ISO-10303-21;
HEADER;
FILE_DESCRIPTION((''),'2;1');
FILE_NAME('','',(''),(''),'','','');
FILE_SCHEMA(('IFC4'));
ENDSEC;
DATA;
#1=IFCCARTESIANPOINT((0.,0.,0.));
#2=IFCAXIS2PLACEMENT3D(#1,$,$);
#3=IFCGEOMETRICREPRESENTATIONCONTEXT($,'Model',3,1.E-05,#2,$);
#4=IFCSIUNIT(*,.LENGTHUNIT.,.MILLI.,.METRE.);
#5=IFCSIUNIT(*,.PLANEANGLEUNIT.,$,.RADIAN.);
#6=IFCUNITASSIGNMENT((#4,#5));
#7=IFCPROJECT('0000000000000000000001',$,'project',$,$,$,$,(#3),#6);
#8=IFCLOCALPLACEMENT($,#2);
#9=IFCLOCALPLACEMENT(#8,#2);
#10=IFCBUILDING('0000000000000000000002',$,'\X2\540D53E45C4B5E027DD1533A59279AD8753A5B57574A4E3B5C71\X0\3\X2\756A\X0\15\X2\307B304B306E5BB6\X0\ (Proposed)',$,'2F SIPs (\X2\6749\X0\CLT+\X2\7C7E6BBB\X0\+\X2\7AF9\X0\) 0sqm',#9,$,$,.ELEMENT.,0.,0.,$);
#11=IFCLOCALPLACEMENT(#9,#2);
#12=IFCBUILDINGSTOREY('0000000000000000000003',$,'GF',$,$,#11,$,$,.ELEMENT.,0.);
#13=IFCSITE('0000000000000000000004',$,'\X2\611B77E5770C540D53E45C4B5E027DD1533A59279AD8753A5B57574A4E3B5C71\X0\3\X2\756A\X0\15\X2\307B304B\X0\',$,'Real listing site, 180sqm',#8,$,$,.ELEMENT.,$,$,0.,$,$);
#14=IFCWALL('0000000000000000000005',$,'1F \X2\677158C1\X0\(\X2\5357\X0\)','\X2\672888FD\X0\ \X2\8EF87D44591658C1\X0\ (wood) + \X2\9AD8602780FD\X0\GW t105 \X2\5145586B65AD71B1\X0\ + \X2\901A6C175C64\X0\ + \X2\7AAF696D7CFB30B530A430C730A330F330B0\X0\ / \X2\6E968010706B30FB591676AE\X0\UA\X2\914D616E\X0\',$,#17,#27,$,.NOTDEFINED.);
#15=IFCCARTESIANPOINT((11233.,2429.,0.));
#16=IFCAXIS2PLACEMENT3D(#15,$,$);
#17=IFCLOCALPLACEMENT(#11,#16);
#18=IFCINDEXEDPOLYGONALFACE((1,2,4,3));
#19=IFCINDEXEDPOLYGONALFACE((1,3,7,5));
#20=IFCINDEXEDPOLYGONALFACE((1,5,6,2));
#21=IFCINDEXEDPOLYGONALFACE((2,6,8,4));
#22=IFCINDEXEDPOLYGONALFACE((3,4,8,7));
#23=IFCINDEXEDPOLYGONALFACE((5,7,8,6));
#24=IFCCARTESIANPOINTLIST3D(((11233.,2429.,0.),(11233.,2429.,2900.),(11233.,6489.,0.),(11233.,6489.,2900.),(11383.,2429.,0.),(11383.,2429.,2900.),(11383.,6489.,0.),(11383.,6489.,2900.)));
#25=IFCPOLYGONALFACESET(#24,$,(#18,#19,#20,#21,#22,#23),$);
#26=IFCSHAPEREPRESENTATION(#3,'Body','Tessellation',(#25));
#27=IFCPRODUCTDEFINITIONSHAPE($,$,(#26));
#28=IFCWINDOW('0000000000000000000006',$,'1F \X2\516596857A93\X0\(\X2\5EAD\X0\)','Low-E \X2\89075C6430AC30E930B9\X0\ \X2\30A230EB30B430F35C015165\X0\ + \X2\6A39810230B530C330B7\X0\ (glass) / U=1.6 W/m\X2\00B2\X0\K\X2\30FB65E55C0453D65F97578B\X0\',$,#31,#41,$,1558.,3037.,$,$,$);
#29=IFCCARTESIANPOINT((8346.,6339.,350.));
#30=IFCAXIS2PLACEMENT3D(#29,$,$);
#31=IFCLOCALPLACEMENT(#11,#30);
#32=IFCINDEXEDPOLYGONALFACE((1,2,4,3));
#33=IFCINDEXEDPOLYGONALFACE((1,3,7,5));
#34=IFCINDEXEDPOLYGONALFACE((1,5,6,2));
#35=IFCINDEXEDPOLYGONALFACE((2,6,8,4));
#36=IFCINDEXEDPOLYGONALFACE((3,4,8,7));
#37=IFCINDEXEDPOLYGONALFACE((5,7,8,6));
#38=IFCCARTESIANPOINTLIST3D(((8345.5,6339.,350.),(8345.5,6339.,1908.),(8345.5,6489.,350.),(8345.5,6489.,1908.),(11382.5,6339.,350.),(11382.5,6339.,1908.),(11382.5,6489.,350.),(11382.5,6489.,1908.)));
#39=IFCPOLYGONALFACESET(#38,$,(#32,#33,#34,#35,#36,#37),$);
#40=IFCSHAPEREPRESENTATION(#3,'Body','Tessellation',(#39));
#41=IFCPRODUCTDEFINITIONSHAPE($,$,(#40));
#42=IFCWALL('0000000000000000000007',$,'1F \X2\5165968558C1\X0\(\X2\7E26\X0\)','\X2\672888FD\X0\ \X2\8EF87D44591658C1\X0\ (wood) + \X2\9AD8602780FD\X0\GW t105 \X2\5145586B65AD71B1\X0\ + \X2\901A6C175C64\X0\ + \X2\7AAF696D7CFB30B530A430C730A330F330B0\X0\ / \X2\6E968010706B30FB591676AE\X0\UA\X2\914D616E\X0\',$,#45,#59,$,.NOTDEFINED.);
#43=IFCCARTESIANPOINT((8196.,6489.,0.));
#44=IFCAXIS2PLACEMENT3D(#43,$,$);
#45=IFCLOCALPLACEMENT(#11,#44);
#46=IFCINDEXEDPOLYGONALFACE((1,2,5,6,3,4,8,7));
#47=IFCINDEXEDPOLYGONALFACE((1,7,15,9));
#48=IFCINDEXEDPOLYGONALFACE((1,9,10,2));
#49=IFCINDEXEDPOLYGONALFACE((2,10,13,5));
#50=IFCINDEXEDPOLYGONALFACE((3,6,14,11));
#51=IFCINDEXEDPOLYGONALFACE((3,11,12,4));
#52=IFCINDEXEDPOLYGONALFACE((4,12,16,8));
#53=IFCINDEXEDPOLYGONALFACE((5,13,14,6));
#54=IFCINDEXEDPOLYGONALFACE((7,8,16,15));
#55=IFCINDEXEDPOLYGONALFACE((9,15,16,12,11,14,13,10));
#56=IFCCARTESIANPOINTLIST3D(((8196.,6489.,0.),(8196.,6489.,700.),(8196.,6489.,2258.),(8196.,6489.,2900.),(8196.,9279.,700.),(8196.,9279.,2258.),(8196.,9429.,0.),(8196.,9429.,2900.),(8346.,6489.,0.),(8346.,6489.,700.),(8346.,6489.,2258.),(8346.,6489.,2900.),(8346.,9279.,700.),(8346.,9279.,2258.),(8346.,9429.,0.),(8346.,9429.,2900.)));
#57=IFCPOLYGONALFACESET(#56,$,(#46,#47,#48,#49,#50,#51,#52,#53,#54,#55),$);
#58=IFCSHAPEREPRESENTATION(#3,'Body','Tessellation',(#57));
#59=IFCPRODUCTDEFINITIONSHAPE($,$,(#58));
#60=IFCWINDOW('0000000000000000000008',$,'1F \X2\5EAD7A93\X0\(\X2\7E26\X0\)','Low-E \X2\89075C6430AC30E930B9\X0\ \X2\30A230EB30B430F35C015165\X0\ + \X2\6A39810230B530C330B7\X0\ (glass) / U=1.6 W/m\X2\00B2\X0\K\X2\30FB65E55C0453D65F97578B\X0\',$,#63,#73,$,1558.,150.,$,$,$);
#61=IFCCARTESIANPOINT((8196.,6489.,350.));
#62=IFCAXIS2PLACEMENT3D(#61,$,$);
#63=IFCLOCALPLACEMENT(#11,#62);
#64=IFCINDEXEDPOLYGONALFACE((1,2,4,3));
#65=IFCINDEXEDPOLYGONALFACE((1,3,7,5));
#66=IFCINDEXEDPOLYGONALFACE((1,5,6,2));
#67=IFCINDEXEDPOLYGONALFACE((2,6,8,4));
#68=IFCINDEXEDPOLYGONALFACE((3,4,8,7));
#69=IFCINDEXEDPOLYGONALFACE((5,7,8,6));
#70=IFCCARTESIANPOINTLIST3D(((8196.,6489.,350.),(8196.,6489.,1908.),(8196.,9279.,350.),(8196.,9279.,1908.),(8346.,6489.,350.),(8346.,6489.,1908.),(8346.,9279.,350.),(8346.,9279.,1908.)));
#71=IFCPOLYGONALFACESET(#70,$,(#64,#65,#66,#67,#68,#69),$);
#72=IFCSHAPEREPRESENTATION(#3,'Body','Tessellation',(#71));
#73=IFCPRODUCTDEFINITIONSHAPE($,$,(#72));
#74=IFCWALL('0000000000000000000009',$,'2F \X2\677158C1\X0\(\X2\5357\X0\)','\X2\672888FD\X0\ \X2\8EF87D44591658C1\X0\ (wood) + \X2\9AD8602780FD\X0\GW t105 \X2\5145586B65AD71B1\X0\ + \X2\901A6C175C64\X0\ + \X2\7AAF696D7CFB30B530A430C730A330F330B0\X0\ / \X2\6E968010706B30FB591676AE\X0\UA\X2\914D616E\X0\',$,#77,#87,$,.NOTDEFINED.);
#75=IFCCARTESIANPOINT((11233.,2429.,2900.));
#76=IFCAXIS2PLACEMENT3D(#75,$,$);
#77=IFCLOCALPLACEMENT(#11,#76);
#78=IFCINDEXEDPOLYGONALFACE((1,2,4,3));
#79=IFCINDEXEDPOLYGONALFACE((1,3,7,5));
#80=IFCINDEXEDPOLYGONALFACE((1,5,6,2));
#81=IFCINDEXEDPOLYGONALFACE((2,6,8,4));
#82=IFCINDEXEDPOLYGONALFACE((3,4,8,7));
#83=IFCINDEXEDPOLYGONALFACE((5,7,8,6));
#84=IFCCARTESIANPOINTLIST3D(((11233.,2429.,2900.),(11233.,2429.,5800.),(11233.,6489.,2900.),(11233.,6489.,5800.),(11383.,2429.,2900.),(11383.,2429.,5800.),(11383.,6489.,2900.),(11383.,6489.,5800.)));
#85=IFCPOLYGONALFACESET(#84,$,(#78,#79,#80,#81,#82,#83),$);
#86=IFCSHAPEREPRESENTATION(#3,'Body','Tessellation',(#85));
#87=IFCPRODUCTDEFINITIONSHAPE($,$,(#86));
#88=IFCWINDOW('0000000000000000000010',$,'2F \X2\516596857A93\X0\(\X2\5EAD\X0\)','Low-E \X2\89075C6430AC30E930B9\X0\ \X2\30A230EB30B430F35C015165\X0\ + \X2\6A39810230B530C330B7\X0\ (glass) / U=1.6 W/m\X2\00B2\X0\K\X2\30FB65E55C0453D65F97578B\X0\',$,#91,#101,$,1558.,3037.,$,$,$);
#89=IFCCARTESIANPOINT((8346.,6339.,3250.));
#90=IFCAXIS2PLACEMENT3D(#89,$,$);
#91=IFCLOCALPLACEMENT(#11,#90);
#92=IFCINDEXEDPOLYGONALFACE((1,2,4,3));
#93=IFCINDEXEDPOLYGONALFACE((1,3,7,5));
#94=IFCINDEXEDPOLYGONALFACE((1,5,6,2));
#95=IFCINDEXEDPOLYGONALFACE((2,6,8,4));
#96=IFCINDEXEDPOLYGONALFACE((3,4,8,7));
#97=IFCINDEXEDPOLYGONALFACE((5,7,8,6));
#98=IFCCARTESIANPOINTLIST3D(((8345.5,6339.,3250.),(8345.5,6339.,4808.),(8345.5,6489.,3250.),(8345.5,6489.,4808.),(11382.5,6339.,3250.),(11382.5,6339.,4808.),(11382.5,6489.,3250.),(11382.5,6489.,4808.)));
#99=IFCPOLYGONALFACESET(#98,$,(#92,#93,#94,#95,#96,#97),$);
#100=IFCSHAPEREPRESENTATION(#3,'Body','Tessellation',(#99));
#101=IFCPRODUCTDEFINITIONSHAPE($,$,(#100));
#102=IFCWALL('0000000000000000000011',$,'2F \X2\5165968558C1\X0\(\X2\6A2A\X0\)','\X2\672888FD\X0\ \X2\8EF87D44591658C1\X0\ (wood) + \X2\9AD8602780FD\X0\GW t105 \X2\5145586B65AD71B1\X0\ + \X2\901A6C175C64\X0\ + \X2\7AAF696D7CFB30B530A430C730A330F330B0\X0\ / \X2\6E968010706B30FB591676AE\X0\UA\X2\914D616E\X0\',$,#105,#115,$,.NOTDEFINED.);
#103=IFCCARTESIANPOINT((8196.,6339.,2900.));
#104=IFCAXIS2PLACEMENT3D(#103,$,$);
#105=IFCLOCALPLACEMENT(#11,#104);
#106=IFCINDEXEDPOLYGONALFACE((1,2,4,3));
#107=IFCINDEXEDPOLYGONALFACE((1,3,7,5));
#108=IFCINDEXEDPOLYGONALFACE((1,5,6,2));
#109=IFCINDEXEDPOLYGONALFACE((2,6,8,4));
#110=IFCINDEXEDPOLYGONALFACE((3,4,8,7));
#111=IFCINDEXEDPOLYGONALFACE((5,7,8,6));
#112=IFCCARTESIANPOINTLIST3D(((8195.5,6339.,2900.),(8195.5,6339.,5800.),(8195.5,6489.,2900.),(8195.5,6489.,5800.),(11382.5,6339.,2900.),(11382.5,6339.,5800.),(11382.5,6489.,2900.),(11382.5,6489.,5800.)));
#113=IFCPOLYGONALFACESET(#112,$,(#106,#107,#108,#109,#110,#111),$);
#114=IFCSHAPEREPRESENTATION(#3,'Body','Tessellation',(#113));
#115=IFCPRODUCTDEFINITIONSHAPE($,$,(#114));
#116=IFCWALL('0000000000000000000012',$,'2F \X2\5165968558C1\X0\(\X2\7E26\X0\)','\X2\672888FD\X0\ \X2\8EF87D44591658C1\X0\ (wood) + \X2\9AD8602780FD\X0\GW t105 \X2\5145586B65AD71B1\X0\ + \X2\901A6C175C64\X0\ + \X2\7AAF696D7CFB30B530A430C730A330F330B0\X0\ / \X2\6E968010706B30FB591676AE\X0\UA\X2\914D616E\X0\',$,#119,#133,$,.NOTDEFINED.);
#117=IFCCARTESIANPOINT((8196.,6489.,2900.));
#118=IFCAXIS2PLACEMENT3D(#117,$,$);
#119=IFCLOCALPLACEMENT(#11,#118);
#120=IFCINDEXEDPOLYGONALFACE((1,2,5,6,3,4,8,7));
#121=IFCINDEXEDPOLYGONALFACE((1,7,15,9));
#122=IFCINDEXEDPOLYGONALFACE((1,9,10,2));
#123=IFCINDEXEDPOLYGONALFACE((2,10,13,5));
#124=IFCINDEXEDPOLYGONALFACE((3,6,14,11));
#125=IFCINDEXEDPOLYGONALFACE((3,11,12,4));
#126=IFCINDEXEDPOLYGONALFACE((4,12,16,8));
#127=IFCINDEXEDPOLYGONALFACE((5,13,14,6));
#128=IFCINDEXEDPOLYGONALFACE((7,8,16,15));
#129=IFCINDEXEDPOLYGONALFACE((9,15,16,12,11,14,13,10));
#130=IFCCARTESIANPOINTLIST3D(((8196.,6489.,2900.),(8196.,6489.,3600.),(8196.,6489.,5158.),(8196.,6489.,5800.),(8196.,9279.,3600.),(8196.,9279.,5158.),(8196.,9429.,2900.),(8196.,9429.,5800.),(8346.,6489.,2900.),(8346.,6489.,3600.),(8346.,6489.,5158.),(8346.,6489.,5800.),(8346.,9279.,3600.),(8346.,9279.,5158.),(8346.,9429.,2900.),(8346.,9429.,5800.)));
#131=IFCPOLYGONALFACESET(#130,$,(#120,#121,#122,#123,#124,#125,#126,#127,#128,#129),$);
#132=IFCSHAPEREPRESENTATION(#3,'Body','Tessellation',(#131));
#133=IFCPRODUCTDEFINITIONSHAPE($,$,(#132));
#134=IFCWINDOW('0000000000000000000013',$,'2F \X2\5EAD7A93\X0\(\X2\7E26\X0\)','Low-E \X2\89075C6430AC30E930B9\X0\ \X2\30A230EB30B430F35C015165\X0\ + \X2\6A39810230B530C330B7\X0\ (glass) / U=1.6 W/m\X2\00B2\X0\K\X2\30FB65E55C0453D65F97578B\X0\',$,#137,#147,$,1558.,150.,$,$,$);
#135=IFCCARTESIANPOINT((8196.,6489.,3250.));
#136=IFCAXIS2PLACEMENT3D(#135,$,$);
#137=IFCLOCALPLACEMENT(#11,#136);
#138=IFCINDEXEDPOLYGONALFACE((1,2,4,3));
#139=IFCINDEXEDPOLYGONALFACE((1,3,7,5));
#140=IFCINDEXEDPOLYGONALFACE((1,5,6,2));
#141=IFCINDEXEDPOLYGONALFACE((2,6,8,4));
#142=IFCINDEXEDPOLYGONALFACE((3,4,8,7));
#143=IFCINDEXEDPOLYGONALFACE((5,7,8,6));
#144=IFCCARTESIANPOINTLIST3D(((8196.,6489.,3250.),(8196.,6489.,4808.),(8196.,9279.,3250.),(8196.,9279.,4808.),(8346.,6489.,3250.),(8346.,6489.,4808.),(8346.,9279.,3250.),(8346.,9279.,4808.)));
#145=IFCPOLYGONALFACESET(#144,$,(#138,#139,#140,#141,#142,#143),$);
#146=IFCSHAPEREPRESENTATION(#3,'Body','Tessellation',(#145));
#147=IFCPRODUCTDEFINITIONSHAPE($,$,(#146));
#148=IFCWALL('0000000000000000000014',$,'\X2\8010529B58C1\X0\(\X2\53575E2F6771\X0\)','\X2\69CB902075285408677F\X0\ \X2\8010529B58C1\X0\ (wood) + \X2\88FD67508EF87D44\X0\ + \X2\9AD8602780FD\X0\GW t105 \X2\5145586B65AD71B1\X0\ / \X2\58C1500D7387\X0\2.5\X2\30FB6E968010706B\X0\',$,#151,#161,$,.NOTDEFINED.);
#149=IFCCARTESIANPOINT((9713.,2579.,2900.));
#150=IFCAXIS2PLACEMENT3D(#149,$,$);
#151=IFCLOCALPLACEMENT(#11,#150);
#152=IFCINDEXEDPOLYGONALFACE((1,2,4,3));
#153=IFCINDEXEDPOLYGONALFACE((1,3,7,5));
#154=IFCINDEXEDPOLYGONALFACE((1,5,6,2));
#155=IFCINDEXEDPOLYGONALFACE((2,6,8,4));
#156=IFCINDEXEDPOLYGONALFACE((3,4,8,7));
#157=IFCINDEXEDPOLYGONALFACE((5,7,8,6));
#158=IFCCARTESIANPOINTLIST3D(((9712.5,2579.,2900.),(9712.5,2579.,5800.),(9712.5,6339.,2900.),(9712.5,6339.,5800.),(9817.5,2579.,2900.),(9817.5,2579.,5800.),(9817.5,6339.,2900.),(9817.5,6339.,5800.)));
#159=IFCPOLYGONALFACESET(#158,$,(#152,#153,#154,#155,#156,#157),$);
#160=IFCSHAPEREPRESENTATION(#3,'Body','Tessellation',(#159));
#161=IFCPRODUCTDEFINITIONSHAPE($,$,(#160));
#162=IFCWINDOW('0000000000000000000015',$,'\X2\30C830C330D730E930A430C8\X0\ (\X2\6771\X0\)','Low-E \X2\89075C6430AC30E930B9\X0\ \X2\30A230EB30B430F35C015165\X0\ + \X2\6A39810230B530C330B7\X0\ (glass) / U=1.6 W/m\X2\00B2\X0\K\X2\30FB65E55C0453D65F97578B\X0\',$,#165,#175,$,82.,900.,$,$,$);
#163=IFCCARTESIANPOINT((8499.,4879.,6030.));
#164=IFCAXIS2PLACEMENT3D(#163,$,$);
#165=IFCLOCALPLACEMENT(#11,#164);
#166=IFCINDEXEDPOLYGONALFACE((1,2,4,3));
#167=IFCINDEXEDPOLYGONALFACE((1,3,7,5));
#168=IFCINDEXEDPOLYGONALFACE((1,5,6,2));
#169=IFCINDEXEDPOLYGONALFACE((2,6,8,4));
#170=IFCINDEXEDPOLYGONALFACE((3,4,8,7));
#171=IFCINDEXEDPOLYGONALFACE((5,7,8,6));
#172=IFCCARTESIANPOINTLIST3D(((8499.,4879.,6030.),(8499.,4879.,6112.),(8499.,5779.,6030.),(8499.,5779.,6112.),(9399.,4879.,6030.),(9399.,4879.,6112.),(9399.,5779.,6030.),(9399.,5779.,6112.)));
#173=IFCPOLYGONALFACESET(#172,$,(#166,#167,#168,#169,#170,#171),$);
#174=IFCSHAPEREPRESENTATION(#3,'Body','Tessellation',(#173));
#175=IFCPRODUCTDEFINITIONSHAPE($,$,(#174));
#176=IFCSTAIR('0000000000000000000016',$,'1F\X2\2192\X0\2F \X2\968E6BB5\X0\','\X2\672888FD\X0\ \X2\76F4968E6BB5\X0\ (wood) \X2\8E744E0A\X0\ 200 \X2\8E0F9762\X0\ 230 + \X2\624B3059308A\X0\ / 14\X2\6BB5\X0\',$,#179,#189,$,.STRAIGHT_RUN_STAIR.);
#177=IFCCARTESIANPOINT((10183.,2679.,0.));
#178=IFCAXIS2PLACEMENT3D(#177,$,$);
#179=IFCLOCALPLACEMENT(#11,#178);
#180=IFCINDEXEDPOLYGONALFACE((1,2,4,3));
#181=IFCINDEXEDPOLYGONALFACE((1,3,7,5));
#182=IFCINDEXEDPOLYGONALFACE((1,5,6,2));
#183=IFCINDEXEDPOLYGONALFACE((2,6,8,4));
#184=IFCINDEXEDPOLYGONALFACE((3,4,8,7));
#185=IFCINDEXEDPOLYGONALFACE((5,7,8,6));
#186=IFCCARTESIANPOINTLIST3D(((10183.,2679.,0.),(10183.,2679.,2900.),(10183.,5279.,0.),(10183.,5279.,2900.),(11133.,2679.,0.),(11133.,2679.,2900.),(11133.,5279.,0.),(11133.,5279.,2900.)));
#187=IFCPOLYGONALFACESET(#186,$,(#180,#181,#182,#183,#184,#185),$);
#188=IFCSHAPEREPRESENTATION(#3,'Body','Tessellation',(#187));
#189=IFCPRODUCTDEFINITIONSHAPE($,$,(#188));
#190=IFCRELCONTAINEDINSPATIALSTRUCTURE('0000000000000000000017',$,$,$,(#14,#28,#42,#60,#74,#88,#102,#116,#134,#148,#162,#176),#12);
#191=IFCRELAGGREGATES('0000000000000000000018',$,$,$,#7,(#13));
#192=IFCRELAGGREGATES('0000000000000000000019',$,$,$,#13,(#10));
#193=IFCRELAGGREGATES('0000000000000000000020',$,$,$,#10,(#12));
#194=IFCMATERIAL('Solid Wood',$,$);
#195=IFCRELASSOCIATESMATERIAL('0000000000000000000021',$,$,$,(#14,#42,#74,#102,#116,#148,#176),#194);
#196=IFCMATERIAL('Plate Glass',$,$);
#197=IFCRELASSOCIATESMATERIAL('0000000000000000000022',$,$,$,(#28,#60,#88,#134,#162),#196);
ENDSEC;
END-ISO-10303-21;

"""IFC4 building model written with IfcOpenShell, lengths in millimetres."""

from ifc_helpers import new_model, si_unit, frame, frame_2d, origin, place, context, project, spatial, rectangle, extrude, material, element, fill, save


model = new_model("IFC4")

# Units and contexts
model_context = context("Model", 3, precision=1e-05, world=origin())
ifc_project = project(units=[si_unit("LENGTHUNIT", "METRE", prefix="MILLI"), si_unit("PLANEANGLEUNIT", "RADIAN")], contexts=[model_context])

# Site, building, storey
site_placement = place(None, origin())
site = spatial("IfcSite", under=ifc_project, at=site_placement, Name="愛知県名古屋市緑区大高町字坊主山3番15ほか", ObjectType="Real listing site, 180sqm", CompositionType="ELEMENT", RefElevation=0.0)
building_placement = place(site_placement, origin())
building = spatial("IfcBuilding", under=site, at=building_placement, Name="名古屋市緑区大高町字坊主山3番15ほかの家 (Proposed)", ObjectType="2F SIPs (杉CLT+籾殻+竹) 0sqm", CompositionType="ELEMENT", ElevationOfRefHeight=0.0, ElevationOfTerrain=0.0)
storey_placement = place(building_placement, origin())
storey = spatial("IfcBuildingStorey", under=building, at=storey_placement, Name="GF", CompositionType="ELEMENT", Elevation=0.0)

# Shared definitions
ifc_material_1 = material(Name="Solid Wood")

# Wall, opening, window
wall_1_placement = place(storey_placement, frame((11233.0, 2429.0, 0.0)))
wall_1 = element("IfcWall", 1, at=wall_1_placement, inside=storey, material=ifc_material_1, Name="1F 東壁(南)", Description="木製 軸組外壁 (wood) + 高性能GW t105 充填断熱 + 通気層 + 窯業系サイディング / 準耐火・外皮UA配慮", PredefinedType="NOTDEFINED", context=model_context, shape_type="SweptSolid", body=[
    extrude(rectangle(XDim=150.0, YDim=4060.0, at=frame_2d((75.0, 2030.0))), frame((11233.0, 2429.0, 0.0)), (0.0, 0.0, 1.0), 2900.0),
])
opening_1_placement = place(storey_placement, frame((8346.0, 6339.0, 350.0)))
opening_1 = element("IfcOpeningElement", 2, at=opening_1_placement, cuts=wall_1, PredefinedType="NOTDEFINED", context=model_context, shape_type="SweptSolid", body=[
    extrude(rectangle(XDim=3037.0, YDim=150.0, at=frame_2d((1518.0, 75.0))), frame((8346.0, 6339.0, 350.0)), (0.0, 0.0, 1.0), 1558.0),
])
ifc_material_2 = material(Name="Plate Glass")
window_1_placement = place(storey_placement, frame((8346.0, 6339.0, 350.0)))
window_1 = element("IfcWindow", 3, at=window_1_placement, inside=storey, material=ifc_material_2, Name="1F 入隅窓(庭)", Description="Low-E 複層ガラス アルゴン封入 + 樹脂サッシ (glass) / U=1.6 W/m²K・日射取得型", OverallHeight=1558.0, OverallWidth=3037.0, context=model_context, shape_type="SweptSolid", body=[
    extrude(rectangle(XDim=3037.0, YDim=150.0, at=frame_2d((1518.0, 75.0))), frame((8346.0, 6339.0, 350.0)), (0.0, 0.0, 1.0), 1558.0),
])
fill(opening_1, window_1)

# Wall, opening, window
wall_2_placement = place(storey_placement, frame((8196.0, 6489.0, 0.0)))
wall_2 = element("IfcWall", 4, at=wall_2_placement, inside=storey, material=ifc_material_1, Name="1F 入隅壁(縦)", Description="木製 軸組外壁 (wood) + 高性能GW t105 充填断熱 + 通気層 + 窯業系サイディング / 準耐火・外皮UA配慮", PredefinedType="NOTDEFINED", context=model_context, shape_type="SweptSolid", body=[
    extrude(rectangle(XDim=150.0, YDim=2940.0, at=frame_2d((75.0, 1470.0))), frame((8196.0, 6489.0, 0.0)), (0.0, 0.0, 1.0), 2900.0),
])
opening_2_placement = place(storey_placement, frame((8196.0, 6489.0, 350.0)))
opening_2 = element("IfcOpeningElement", 5, at=opening_2_placement, cuts=wall_2, PredefinedType="NOTDEFINED", context=model_context, shape_type="SweptSolid", body=[
    extrude(rectangle(XDim=150.0, YDim=2790.0, at=frame_2d((75.0, 1395.0))), frame((8196.0, 6489.0, 350.0)), (0.0, 0.0, 1.0), 1558.0),
])
window_2_placement = place(storey_placement, frame((8196.0, 6489.0, 350.0)))
window_2 = element("IfcWindow", 6, at=window_2_placement, inside=storey, material=ifc_material_2, Name="1F 庭窓(縦)", Description="Low-E 複層ガラス アルゴン封入 + 樹脂サッシ (glass) / U=1.6 W/m²K・日射取得型", OverallHeight=1558.0, OverallWidth=150.0, context=model_context, shape_type="SweptSolid", body=[
    extrude(rectangle(XDim=150.0, YDim=2790.0, at=frame_2d((75.0, 1395.0))), frame((8196.0, 6489.0, 350.0)), (0.0, 0.0, 1.0), 1558.0),
])
fill(opening_2, window_2)

# Wall, opening, window
wall_3_placement = place(storey_placement, frame((11233.0, 2429.0, 2900.0)))
wall_3 = element("IfcWall", 7, at=wall_3_placement, inside=storey, material=ifc_material_1, Name="2F 東壁(南)", Description="木製 軸組外壁 (wood) + 高性能GW t105 充填断熱 + 通気層 + 窯業系サイディング / 準耐火・外皮UA配慮", PredefinedType="NOTDEFINED", context=model_context, shape_type="SweptSolid", body=[
    extrude(rectangle(XDim=150.0, YDim=4060.0, at=frame_2d((75.0, 2030.0))), frame((11233.0, 2429.0, 2900.0)), (0.0, 0.0, 1.0), 2900.0),
])
opening_3_placement = place(storey_placement, frame((8346.0, 6339.0, 3250.0)))
opening_3 = element("IfcOpeningElement", 8, at=opening_3_placement, cuts=wall_3, PredefinedType="NOTDEFINED", context=model_context, shape_type="SweptSolid", body=[
    extrude(rectangle(XDim=3037.0, YDim=150.0, at=frame_2d((1518.0, 75.0))), frame((8346.0, 6339.0, 3250.0)), (0.0, 0.0, 1.0), 1558.0),
])
window_3_placement = place(storey_placement, frame((8346.0, 6339.0, 3250.0)))
window_3 = element("IfcWindow", 9, at=window_3_placement, inside=storey, material=ifc_material_2, Name="2F 入隅窓(庭)", Description="Low-E 複層ガラス アルゴン封入 + 樹脂サッシ (glass) / U=1.6 W/m²K・日射取得型", OverallHeight=1558.0, OverallWidth=3037.0, context=model_context, shape_type="SweptSolid", body=[
    extrude(rectangle(XDim=3037.0, YDim=150.0, at=frame_2d((1518.0, 75.0))), frame((8346.0, 6339.0, 3250.0)), (0.0, 0.0, 1.0), 1558.0),
])
fill(opening_3, window_3)

# Wall
wall_4_placement = place(storey_placement, frame((8196.0, 6339.0, 2900.0)))
element("IfcWall", 10, at=wall_4_placement, inside=storey, material=ifc_material_1, Name="2F 入隅壁(横)", Description="木製 軸組外壁 (wood) + 高性能GW t105 充填断熱 + 通気層 + 窯業系サイディング / 準耐火・外皮UA配慮", PredefinedType="NOTDEFINED", context=model_context, shape_type="SweptSolid", body=[
    extrude(rectangle(XDim=3187.0, YDim=150.0, at=frame_2d((1593.0, 75.0))), frame((8196.0, 6339.0, 2900.0)), (0.0, 0.0, 1.0), 2900.0),
])

# Wall, opening, window
wall_5_placement = place(storey_placement, frame((8196.0, 6489.0, 2900.0)))
wall_5 = element("IfcWall", 11, at=wall_5_placement, inside=storey, material=ifc_material_1, Name="2F 入隅壁(縦)", Description="木製 軸組外壁 (wood) + 高性能GW t105 充填断熱 + 通気層 + 窯業系サイディング / 準耐火・外皮UA配慮", PredefinedType="NOTDEFINED", context=model_context, shape_type="SweptSolid", body=[
    extrude(rectangle(XDim=150.0, YDim=2940.0, at=frame_2d((75.0, 1470.0))), frame((8196.0, 6489.0, 2900.0)), (0.0, 0.0, 1.0), 2900.0),
])
opening_4_placement = place(storey_placement, frame((8196.0, 6489.0, 3250.0)))
opening_4 = element("IfcOpeningElement", 12, at=opening_4_placement, cuts=wall_5, PredefinedType="NOTDEFINED", context=model_context, shape_type="SweptSolid", body=[
    extrude(rectangle(XDim=150.0, YDim=2790.0, at=frame_2d((75.0, 1395.0))), frame((8196.0, 6489.0, 3250.0)), (0.0, 0.0, 1.0), 1558.0),
])
window_4_placement = place(storey_placement, frame((8196.0, 6489.0, 3250.0)))
window_4 = element("IfcWindow", 13, at=window_4_placement, inside=storey, material=ifc_material_2, Name="2F 庭窓(縦)", Description="Low-E 複層ガラス アルゴン封入 + 樹脂サッシ (glass) / U=1.6 W/m²K・日射取得型", OverallHeight=1558.0, OverallWidth=150.0, context=model_context, shape_type="SweptSolid", body=[
    extrude(rectangle(XDim=150.0, YDim=2790.0, at=frame_2d((75.0, 1395.0))), frame((8196.0, 6489.0, 3250.0)), (0.0, 0.0, 1.0), 1558.0),
])
fill(opening_4, window_4)

# Wall
wall_6_placement = place(storey_placement, frame((9713.0, 2579.0, 2900.0)))
element("IfcWall", 14, at=wall_6_placement, inside=storey, material=ifc_material_1, Name="耐力壁(南帯東)", Description="構造用合板 耐力壁 (wood) + 製材軸組 + 高性能GW t105 充填断熱 / 壁倍率2.5・準耐火", PredefinedType="NOTDEFINED", context=model_context, shape_type="SweptSolid", body=[
    extrude(rectangle(XDim=105.0, YDim=3760.0, at=frame_2d((52.0, 1880.0))), frame((9713.0, 2579.0, 2900.0)), (0.0, 0.0, 1.0), 2900.0),
])

# Window
window_5_placement = place(storey_placement, frame((8499.0, 4879.0, 6030.0)))
element("IfcWindow", 15, at=window_5_placement, inside=storey, material=ifc_material_2, Name="トップライト (東)", Description="Low-E 複層ガラス アルゴン封入 + 樹脂サッシ (glass) / U=1.6 W/m²K・日射取得型", OverallHeight=82.0, OverallWidth=900.0, context=model_context, shape_type="SweptSolid", body=[
    extrude(rectangle(XDim=900.0, YDim=900.0, at=frame_2d((450.0, 450.0))), frame((8499.0, 4879.0, 6030.0)), (0.0, 0.0, 1.0), 82.0),
])

# Stair
stair_placement = place(storey_placement, frame((10183.0, 2679.0, 0.0)))
element("IfcStair", 16, at=stair_placement, inside=storey, material=ifc_material_1, Name="1F→2F 階段", Description="木製 直階段 (wood) 蹴上 200 踏面 230 + 手すり / 14段", PredefinedType="STRAIGHT_RUN_STAIR", context=model_context, shape_type="SweptSolid", body=[
    extrude(rectangle(XDim=950.0, YDim=2600.0, at=frame_2d((475.0, 1300.0))), frame((10183.0, 2679.0, 0.0)), (0.0, 0.0, 1.0), 2900.0),
])

save(model, "model.ifc")
